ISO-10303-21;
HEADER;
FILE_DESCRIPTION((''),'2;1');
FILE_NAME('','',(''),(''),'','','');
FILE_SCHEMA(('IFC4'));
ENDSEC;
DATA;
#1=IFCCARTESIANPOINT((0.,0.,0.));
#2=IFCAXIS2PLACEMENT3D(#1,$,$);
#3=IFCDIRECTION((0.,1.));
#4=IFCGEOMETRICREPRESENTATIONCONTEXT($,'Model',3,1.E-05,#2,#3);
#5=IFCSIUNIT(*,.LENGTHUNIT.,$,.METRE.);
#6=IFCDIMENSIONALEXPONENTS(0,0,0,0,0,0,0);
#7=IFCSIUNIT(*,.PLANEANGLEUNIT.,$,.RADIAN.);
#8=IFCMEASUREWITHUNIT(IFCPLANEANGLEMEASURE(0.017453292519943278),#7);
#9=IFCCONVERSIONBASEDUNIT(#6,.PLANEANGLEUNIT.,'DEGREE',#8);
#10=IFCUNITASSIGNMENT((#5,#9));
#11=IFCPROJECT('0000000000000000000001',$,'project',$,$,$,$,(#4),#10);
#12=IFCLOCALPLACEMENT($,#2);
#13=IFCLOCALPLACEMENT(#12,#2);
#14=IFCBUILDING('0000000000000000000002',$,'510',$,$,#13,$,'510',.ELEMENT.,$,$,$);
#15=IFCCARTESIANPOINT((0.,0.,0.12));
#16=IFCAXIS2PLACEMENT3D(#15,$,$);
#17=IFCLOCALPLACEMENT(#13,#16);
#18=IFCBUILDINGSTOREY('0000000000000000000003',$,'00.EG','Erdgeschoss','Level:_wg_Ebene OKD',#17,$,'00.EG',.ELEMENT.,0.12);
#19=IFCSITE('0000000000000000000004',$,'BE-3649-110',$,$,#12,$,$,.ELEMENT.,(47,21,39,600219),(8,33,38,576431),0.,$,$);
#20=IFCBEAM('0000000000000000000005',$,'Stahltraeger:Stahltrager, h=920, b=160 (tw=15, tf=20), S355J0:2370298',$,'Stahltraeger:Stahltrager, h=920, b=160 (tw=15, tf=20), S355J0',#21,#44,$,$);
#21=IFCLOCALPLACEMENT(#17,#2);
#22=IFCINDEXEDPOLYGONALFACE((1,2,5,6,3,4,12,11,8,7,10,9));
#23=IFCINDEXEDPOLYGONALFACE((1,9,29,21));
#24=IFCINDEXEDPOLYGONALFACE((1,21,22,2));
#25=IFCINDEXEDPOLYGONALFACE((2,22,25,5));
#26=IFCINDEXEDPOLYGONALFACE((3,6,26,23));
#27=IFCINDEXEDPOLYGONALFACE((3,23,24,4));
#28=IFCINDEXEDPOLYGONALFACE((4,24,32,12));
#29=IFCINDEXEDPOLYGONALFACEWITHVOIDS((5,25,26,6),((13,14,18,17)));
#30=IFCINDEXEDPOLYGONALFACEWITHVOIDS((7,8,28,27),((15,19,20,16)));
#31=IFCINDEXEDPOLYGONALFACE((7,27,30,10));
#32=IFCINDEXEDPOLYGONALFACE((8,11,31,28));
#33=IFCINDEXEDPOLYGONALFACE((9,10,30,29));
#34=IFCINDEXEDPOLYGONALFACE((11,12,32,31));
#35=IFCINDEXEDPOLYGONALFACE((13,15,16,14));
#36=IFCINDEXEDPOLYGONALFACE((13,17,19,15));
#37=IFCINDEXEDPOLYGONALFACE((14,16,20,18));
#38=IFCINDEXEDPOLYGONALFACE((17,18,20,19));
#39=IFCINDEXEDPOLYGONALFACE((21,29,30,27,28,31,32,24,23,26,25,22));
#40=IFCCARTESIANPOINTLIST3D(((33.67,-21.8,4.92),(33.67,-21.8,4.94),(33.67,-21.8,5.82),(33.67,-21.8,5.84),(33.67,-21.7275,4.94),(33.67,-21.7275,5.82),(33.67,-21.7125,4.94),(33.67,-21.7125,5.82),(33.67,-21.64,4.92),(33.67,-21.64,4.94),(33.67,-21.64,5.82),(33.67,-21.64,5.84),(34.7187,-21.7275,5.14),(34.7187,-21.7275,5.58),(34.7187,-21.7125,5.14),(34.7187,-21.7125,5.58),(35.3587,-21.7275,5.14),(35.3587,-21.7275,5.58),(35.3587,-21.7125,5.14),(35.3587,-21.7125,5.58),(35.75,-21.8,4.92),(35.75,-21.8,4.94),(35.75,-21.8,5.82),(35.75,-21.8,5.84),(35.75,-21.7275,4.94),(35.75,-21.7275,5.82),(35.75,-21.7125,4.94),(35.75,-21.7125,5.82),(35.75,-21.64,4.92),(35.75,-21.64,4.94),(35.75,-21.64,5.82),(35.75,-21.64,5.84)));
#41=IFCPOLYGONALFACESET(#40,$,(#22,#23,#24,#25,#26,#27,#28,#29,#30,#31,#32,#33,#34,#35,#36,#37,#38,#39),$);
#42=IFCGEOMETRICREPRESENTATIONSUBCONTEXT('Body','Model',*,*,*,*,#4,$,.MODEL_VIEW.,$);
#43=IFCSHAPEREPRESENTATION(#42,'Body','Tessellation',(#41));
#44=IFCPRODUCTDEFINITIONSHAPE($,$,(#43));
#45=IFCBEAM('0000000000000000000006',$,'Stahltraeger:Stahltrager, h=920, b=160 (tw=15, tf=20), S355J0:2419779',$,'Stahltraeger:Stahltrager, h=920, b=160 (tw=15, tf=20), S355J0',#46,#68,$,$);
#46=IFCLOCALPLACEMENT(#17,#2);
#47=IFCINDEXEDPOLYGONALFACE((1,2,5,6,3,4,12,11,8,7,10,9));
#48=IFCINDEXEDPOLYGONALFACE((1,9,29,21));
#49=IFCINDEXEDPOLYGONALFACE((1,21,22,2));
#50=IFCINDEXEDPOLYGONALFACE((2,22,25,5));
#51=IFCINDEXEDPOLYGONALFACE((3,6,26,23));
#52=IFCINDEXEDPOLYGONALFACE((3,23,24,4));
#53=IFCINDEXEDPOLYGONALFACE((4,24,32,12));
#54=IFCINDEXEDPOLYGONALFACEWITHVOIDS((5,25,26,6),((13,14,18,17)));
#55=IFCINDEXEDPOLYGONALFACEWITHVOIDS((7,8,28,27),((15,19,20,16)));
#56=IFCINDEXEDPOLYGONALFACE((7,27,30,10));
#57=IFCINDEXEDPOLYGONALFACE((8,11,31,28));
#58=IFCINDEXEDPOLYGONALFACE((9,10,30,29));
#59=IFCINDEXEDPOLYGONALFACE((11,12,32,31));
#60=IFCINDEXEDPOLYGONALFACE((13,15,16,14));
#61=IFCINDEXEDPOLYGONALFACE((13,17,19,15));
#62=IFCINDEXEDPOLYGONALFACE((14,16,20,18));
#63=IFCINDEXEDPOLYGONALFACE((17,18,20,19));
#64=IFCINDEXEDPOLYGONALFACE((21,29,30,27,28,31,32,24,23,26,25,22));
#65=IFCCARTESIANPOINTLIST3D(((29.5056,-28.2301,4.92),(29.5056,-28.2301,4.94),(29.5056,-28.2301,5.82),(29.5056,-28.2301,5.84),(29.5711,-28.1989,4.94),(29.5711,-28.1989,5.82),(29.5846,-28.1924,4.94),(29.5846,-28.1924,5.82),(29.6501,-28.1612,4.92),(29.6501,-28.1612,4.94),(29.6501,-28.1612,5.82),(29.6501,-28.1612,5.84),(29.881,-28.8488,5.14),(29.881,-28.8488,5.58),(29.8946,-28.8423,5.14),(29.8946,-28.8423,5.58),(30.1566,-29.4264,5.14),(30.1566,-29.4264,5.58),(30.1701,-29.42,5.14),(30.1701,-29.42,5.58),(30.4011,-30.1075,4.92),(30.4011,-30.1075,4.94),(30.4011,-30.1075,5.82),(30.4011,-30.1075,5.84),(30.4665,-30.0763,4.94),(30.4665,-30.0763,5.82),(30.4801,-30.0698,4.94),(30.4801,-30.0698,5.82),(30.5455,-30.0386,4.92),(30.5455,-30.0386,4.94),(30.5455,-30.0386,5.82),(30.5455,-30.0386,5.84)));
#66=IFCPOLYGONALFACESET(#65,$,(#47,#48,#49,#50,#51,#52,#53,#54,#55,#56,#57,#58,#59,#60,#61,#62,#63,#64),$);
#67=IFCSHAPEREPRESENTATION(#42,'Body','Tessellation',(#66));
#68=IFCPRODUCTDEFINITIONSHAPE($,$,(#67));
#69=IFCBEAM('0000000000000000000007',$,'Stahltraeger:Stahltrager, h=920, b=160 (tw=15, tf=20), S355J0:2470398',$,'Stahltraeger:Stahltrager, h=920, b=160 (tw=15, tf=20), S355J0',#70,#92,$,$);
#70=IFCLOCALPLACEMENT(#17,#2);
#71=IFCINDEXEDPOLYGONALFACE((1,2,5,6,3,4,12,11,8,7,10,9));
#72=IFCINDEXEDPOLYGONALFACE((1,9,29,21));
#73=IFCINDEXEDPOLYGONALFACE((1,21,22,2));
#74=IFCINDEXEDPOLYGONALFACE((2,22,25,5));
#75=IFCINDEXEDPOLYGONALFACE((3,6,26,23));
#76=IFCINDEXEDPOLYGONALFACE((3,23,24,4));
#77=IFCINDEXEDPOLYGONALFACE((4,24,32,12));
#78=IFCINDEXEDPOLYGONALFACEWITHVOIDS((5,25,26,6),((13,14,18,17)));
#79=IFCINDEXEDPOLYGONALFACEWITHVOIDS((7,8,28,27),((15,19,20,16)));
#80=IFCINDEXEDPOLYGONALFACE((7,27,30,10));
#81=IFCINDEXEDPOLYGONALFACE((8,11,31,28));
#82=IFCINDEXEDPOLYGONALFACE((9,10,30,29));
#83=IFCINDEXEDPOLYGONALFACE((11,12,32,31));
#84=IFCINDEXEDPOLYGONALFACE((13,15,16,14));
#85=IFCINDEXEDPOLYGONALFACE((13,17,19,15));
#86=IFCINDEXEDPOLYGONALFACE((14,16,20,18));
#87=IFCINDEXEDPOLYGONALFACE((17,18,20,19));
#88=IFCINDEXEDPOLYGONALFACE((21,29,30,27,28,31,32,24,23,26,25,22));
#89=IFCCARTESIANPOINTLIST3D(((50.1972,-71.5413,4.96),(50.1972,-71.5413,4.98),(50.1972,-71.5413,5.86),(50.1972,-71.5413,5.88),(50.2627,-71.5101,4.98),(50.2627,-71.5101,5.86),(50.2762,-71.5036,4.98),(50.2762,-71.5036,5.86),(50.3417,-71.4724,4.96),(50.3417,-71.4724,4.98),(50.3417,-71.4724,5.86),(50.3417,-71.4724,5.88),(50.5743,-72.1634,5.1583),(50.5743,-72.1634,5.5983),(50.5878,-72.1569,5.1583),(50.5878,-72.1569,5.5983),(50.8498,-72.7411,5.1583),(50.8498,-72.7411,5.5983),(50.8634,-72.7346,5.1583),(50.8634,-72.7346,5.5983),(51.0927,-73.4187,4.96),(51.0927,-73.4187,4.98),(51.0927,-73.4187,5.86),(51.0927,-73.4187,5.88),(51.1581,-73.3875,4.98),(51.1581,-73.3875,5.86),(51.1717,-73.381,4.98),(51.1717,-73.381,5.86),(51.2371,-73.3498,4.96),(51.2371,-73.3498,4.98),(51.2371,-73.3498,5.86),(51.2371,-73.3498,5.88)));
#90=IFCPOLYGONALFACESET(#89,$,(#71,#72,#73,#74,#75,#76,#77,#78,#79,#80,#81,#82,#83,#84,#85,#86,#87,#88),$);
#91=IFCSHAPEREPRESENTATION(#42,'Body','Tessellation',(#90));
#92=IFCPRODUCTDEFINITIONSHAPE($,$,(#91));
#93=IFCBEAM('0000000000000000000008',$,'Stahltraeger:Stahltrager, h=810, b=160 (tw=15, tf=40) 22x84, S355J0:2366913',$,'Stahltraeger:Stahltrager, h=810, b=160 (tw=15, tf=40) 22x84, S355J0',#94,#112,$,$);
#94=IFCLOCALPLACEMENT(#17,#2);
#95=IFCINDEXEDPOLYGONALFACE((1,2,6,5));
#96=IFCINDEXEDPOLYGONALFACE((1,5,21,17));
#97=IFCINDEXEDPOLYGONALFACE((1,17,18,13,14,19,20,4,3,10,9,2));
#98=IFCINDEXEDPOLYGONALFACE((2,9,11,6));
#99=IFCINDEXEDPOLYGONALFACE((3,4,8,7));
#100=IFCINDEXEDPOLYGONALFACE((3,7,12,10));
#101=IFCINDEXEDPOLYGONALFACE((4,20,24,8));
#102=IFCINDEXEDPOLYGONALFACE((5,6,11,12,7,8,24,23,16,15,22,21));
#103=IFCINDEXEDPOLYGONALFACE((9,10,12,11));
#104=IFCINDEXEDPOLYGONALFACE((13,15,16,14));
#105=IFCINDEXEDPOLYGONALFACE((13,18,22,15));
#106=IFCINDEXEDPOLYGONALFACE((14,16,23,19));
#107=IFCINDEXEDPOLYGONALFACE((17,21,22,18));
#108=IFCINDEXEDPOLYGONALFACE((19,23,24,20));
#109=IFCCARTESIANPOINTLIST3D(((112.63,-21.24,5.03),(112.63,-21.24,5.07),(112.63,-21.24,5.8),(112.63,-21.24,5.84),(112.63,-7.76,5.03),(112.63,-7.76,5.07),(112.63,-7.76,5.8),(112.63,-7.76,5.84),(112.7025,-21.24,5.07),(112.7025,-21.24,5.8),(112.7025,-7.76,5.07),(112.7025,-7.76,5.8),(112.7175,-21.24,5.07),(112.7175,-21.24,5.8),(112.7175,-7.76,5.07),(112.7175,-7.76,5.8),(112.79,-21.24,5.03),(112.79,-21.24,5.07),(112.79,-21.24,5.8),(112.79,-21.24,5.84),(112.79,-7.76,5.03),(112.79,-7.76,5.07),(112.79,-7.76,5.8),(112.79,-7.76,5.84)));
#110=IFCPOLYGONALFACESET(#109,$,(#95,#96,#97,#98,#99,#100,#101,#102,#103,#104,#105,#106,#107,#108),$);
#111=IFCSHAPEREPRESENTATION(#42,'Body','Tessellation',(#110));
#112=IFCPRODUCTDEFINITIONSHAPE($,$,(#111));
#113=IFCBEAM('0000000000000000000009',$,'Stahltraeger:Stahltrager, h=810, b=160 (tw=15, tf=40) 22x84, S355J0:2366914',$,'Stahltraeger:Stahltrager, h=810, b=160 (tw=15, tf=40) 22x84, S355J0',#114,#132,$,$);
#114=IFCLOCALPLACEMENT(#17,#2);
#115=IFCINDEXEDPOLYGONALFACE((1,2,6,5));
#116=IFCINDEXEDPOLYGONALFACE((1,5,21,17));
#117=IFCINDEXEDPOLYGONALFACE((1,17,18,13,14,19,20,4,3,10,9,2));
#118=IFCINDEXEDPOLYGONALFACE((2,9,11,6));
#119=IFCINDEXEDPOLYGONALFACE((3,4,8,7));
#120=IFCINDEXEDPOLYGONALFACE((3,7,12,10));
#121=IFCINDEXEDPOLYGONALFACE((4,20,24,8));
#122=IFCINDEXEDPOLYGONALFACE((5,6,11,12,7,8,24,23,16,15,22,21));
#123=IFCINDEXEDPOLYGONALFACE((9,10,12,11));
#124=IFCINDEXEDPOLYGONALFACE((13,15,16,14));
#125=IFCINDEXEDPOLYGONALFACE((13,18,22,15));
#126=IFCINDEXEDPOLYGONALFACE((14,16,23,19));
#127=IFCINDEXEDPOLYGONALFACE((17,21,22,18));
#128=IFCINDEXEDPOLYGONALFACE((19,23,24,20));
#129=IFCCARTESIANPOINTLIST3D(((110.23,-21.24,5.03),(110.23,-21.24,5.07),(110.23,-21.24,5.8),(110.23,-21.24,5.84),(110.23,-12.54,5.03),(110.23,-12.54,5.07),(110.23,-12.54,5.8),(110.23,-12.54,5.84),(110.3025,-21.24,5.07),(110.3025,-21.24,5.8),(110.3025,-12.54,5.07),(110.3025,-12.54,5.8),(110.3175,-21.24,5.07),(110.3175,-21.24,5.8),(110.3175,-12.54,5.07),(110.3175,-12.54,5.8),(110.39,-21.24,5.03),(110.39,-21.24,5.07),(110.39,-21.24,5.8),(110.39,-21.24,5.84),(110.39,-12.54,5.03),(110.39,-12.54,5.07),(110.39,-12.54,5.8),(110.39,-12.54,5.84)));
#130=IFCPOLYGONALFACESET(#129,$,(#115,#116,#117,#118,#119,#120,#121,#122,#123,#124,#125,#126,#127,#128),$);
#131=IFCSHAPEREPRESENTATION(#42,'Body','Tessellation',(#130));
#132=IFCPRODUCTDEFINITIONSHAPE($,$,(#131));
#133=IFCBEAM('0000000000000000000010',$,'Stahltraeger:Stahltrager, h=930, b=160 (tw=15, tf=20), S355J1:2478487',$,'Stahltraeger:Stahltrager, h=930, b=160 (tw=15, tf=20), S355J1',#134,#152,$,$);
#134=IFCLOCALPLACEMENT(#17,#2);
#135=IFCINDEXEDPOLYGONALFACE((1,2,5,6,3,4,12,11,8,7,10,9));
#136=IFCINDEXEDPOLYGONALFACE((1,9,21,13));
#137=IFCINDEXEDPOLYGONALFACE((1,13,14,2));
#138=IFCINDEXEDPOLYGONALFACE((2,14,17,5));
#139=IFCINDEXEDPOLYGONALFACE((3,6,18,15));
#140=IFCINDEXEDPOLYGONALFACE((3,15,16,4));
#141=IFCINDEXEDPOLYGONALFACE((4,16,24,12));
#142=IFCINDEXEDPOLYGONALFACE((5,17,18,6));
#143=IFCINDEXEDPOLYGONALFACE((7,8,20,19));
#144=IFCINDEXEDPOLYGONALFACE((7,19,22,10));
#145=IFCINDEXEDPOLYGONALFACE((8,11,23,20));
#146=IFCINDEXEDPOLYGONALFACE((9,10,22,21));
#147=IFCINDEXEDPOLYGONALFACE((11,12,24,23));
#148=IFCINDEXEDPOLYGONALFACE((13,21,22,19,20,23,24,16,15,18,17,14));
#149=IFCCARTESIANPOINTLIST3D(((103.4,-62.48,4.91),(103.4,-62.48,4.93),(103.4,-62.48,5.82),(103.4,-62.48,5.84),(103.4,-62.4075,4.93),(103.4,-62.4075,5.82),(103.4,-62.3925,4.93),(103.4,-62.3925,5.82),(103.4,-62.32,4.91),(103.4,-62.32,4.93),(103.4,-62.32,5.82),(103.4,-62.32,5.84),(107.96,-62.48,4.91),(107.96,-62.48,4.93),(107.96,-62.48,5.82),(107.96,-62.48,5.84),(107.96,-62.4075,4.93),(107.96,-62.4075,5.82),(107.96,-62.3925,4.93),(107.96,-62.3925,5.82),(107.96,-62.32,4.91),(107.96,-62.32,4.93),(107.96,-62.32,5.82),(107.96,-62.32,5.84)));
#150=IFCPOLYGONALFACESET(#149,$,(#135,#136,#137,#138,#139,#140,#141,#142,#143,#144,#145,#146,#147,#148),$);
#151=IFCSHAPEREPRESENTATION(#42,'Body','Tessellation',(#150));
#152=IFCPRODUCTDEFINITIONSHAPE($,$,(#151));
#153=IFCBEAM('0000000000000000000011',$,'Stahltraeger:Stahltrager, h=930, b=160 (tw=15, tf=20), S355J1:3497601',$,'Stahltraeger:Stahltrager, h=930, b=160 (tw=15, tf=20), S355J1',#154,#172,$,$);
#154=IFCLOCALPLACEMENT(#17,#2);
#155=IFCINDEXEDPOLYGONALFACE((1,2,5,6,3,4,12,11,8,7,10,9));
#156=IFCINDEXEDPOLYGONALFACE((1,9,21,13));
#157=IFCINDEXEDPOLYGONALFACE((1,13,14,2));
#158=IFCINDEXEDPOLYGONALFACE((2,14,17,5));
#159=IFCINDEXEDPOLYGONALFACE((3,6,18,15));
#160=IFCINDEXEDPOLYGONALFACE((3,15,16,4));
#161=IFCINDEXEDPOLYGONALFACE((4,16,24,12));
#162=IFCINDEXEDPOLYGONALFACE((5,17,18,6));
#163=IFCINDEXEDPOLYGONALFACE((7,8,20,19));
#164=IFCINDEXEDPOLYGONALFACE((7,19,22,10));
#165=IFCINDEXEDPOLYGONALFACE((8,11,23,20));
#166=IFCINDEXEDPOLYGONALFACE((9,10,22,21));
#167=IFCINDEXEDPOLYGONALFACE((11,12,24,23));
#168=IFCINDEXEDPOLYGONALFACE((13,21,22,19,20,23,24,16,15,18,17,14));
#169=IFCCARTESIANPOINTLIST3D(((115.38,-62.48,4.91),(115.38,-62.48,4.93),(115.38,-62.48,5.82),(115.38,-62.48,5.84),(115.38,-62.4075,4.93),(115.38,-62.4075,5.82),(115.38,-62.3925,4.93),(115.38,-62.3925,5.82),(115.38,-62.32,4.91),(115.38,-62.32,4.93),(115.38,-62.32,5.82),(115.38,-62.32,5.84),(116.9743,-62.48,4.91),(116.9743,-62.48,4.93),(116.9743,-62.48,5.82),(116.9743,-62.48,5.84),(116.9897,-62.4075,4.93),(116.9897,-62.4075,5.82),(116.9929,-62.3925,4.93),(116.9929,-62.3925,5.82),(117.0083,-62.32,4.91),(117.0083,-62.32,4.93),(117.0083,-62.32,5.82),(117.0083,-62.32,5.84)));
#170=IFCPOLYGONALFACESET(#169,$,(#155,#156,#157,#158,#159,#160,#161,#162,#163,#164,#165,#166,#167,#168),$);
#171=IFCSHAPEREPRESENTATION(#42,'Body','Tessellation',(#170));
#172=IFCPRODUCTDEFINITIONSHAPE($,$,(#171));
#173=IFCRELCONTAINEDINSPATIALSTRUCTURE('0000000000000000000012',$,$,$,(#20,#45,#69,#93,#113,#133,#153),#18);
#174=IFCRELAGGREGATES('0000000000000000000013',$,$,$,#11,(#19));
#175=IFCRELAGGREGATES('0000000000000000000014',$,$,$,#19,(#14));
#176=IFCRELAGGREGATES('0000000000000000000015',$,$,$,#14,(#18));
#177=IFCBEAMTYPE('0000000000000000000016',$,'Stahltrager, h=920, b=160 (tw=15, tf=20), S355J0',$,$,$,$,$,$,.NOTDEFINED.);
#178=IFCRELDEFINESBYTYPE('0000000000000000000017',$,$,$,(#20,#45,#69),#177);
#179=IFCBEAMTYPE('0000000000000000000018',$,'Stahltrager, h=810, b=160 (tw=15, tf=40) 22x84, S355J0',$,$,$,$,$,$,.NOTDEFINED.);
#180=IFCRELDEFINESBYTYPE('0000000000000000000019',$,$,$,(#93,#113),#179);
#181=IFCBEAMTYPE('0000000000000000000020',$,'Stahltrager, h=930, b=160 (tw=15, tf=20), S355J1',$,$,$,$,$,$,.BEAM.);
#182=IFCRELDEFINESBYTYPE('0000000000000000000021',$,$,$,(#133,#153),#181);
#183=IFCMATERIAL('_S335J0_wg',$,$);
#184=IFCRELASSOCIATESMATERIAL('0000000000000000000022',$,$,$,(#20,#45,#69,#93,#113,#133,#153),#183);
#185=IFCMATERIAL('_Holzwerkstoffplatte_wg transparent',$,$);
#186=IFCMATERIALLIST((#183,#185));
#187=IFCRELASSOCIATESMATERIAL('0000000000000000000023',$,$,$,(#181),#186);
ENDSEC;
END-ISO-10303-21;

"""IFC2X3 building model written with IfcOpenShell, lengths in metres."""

from ifc_helpers import new_model, entity, si_unit, converted_unit, direction, frame, frame_2d, origin, place, context, subcontext, project, spatial, rectangle, i_section, extrude, boolean, clip, halfspace, material, material_list, type_object, element, save


model = new_model("IFC2X3")

# Units and contexts
model_context = context("Model", 3, precision=1e-05, world=origin(), true_north=direction((0.0, 1.0)))
body_context = subcontext(model_context, "Body", "Model", "MODEL_VIEW")
ifc_project = project(units=[si_unit("LENGTHUNIT", "METRE"), converted_unit("PLANEANGLEUNIT", "DEGREE", entity("IfcPlaneAngleMeasure", 0.017453292519943278), si_unit("PLANEANGLEUNIT", "RADIAN"), dimensions=[0, 0, 0, 0, 0, 0, 0])], contexts=[model_context])

# Site, building, storey
site_placement = place(None, origin())
site = spatial("IfcSite", under=ifc_project, at=site_placement, Name="BE-3649-110", CompositionType="ELEMENT", RefLatitude=(47, 21, 39, 600219), RefLongitude=(8, 33, 38, 576431), RefElevation=0.0)
building_placement = place(site_placement, origin())
building = spatial("IfcBuilding", under=site, at=building_placement, Name="510", LongName="510", CompositionType="ELEMENT")
storey_placement = place(building_placement, frame((0.0, 0.0, 0.12)))
storey = spatial("IfcBuildingStorey", under=building, at=storey_placement, Name="00.EG", Description="Erdgeschoss", ObjectType="Level:_wg_Ebene OKD", LongName="00.EG", CompositionType="ELEMENT", Elevation=0.12)

# Beams
ifc_material_1 = material(Name="_S335J0_wg")
beam_type_1 = type_object("IfcBeamType", Name="Stahltrager, h=920, b=160 (tw=15, tf=20), S355J0", PredefinedType="NOTDEFINED")
beam_1_placement = place(storey_placement, frame((33.67, -21.72, 5.84)))
element("IfcBeam", 1, at=beam_1_placement, inside=storey, type_object=beam_type_1, material=ifc_material_1, Name="Stahltraeger:Stahltrager, h=920, b=160 (tw=15, tf=20), S355J0:2370298", ObjectType="Stahltraeger:Stahltrager, h=920, b=160 (tw=15, tf=20), S355J0", context=body_context, shape_type="SweptSolid", body=[
    boolean("DIFFERENCE", extrude(i_section(OverallWidth=0.16, OverallDepth=0.92, WebThickness=0.015, FlangeThickness=0.02, at=frame_2d((0.0, 0.0), x_axis=(0.0, 1.0))), frame((0.0, 0.0, -0.46), z_axis=(1.0, 0.0, 0.0), x_axis=(0.0, 0.0, -1.0)), (0.0, 0.0, 1.0), 2.08), extrude(rectangle(XDim=0.44, YDim=0.64, at=frame_2d((0.0, 0.0), x_axis=(0.0, 1.0))), frame((1.3687, 0.0075, -0.48), z_axis=(0.0, -1.0, 0.0), x_axis=(-1.0, 0.0, 0.0)), (0.0, 0.0, 1.0), 0.015)),
])
beam_2_placement = place(storey_placement, frame((30.4733, -30.073, 5.84), z_axis=(0.0, 0.0, 1.0), x_axis=(-0.430511, 0.902585, 0.0)))
element("IfcBeam", 2, at=beam_2_placement, inside=storey, type_object=beam_type_1, material=ifc_material_1, Name="Stahltraeger:Stahltrager, h=920, b=160 (tw=15, tf=20), S355J0:2419779", ObjectType="Stahltraeger:Stahltrager, h=920, b=160 (tw=15, tf=20), S355J0", context=body_context, shape_type="SweptSolid", body=[
    boolean("DIFFERENCE", extrude(i_section(OverallWidth=0.16, OverallDepth=0.92, WebThickness=0.015, FlangeThickness=0.02, at=frame_2d((0.0, 0.0), x_axis=(0.0, 1.0))), frame((0.0, 0.0, -0.46), z_axis=(1.0, 0.0, 0.0), x_axis=(0.0, 0.0, -1.0)), (0.0, 0.0, 1.0), 2.08), extrude(rectangle(XDim=0.44, YDim=0.64, at=frame_2d((0.0, 0.0), x_axis=(0.0, 1.0))), frame((1.04, 0.0075, -0.48), z_axis=(0.0, -1.0, 0.0), x_axis=(-1.0, 0.0, 0.0)), (0.0, 0.0, 1.0), 0.015)),
])
beam_3_placement = place(storey_placement, frame((50.2695, -71.5068, 5.84), z_axis=(0.0, 0.0, 1.0), x_axis=(0.430511, -0.902585, 0.0)))
element("IfcBeam", 3, at=beam_3_placement, inside=storey, type_object=beam_type_1, material=ifc_material_1, Name="Stahltraeger:Stahltrager, h=920, b=160 (tw=15, tf=20), S355J0:2470398", ObjectType="Stahltraeger:Stahltrager, h=920, b=160 (tw=15, tf=20), S355J0", context=body_context, shape_type="SweptSolid", body=[
    boolean("DIFFERENCE", extrude(i_section(OverallWidth=0.16, OverallDepth=0.92, WebThickness=0.015, FlangeThickness=0.02, at=frame_2d((0.0, 0.0), x_axis=(0.0, 1.0))), frame((0.0, 0.0, -0.42), z_axis=(1.0, 0.0, 0.0), x_axis=(0.0, 0.0, -1.0)), (0.0, 0.0, 1.0), 2.08), extrude(rectangle(XDim=0.44, YDim=0.64, at=frame_2d((0.0, 0.0), x_axis=(0.0, 1.0))), frame((1.0438, 0.0075, -0.4617), z_axis=(0.0, -1.0, 0.0), x_axis=(-1.0, 0.0, 0.0)), (0.0, 0.0, 1.0), 0.015)),
])
beam_type_2 = type_object("IfcBeamType", Name="Stahltrager, h=810, b=160 (tw=15, tf=40) 22x84, S355J0", PredefinedType="NOTDEFINED")
beam_4_placement = place(storey_placement, frame((112.71, -7.76, 5.84), z_axis=(0.0, 0.0, 1.0), x_axis=(0.0, -1.0, 0.0)))
element("IfcBeam", 4, at=beam_4_placement, inside=storey, type_object=beam_type_2, material=ifc_material_1, Name="Stahltraeger:Stahltrager, h=810, b=160 (tw=15, tf=40) 22x84, S355J0:2366913", ObjectType="Stahltraeger:Stahltrager, h=810, b=160 (tw=15, tf=40) 22x84, S355J0", context=body_context, shape_type="SweptSolid", body=[
    extrude(i_section(OverallWidth=0.16, OverallDepth=0.81, WebThickness=0.015, FlangeThickness=0.04, at=frame_2d((0.0, 0.0), x_axis=(0.0, 1.0))), frame((0.0, 0.0, -0.405), z_axis=(1.0, 0.0, 0.0), x_axis=(0.0, 0.0, -1.0)), (0.0, 0.0, 1.0), 13.48),
])
beam_5_placement = place(storey_placement, frame((110.31, -12.54, 5.84), z_axis=(0.0, 0.0, 1.0), x_axis=(0.0, -1.0, 0.0)))
element("IfcBeam", 5, at=beam_5_placement, inside=storey, type_object=beam_type_2, material=ifc_material_1, Name="Stahltraeger:Stahltrager, h=810, b=160 (tw=15, tf=40) 22x84, S355J0:2366914", ObjectType="Stahltraeger:Stahltrager, h=810, b=160 (tw=15, tf=40) 22x84, S355J0", context=body_context, shape_type="SweptSolid", body=[
    extrude(i_section(OverallWidth=0.16, OverallDepth=0.81, WebThickness=0.015, FlangeThickness=0.04, at=frame_2d((0.0, 0.0), x_axis=(0.0, 1.0))), frame((0.0, 0.0, -0.405), z_axis=(1.0, 0.0, 0.0), x_axis=(0.0, 0.0, -1.0)), (0.0, 0.0, 1.0), 8.7),
])
ifc_material_2 = material(Name="_Holzwerkstoffplatte_wg transparent")
ifc_material_list = material_list([ifc_material_1, ifc_material_2])
beam_type_3 = type_object("IfcBeamType", Name="Stahltrager, h=930, b=160 (tw=15, tf=20), S355J1", PredefinedType="BEAM", material=ifc_material_list)
beam_6_placement = place(storey_placement, frame((103.4, -62.4, 5.84)))
element("IfcBeam", 6, at=beam_6_placement, inside=storey, type_object=beam_type_3, material=ifc_material_1, Name="Stahltraeger:Stahltrager, h=930, b=160 (tw=15, tf=20), S355J1:2478487", ObjectType="Stahltraeger:Stahltrager, h=930, b=160 (tw=15, tf=20), S355J1", context=body_context, shape_type="SweptSolid", body=[
    extrude(i_section(OverallWidth=0.16, OverallDepth=0.93, WebThickness=0.015, FlangeThickness=0.02, at=frame_2d((0.0, 0.0), x_axis=(0.0, 1.0))), frame((0.0, 0.0, -0.465), z_axis=(1.0, 0.0, 0.0), x_axis=(0.0, 0.0, -1.0)), (0.0, 0.0, 1.0), 4.56),
])
beam_7_placement = place(storey_placement, frame((115.38, -62.4, 5.84)))
element("IfcBeam", 7, at=beam_7_placement, inside=storey, type_object=beam_type_3, material=ifc_material_1, Name="Stahltraeger:Stahltrager, h=930, b=160 (tw=15, tf=20), S355J1:3497601", ObjectType="Stahltraeger:Stahltrager, h=930, b=160 (tw=15, tf=20), S355J1", context=body_context, shape_type="SweptSolid", body=[
    clip(extrude(i_section(OverallWidth=0.16, OverallDepth=0.93, WebThickness=0.015, FlangeThickness=0.02, at=frame_2d((0.0, 0.0), x_axis=(0.0, 1.0))), frame((0.0, 0.0, -0.465), z_axis=(1.0, 0.0, 0.0), x_axis=(0.0, 0.0, -1.0)), (0.0, 0.0, 1.0), 1.6282), halfspace(frame((1.5374, -0.3476, 18.82), z_axis=(0.978148, -0.207912, 0.0), x_axis=(0.207912, 0.978148, 0.0)), False)),
])

save(model, "model.ifc")
